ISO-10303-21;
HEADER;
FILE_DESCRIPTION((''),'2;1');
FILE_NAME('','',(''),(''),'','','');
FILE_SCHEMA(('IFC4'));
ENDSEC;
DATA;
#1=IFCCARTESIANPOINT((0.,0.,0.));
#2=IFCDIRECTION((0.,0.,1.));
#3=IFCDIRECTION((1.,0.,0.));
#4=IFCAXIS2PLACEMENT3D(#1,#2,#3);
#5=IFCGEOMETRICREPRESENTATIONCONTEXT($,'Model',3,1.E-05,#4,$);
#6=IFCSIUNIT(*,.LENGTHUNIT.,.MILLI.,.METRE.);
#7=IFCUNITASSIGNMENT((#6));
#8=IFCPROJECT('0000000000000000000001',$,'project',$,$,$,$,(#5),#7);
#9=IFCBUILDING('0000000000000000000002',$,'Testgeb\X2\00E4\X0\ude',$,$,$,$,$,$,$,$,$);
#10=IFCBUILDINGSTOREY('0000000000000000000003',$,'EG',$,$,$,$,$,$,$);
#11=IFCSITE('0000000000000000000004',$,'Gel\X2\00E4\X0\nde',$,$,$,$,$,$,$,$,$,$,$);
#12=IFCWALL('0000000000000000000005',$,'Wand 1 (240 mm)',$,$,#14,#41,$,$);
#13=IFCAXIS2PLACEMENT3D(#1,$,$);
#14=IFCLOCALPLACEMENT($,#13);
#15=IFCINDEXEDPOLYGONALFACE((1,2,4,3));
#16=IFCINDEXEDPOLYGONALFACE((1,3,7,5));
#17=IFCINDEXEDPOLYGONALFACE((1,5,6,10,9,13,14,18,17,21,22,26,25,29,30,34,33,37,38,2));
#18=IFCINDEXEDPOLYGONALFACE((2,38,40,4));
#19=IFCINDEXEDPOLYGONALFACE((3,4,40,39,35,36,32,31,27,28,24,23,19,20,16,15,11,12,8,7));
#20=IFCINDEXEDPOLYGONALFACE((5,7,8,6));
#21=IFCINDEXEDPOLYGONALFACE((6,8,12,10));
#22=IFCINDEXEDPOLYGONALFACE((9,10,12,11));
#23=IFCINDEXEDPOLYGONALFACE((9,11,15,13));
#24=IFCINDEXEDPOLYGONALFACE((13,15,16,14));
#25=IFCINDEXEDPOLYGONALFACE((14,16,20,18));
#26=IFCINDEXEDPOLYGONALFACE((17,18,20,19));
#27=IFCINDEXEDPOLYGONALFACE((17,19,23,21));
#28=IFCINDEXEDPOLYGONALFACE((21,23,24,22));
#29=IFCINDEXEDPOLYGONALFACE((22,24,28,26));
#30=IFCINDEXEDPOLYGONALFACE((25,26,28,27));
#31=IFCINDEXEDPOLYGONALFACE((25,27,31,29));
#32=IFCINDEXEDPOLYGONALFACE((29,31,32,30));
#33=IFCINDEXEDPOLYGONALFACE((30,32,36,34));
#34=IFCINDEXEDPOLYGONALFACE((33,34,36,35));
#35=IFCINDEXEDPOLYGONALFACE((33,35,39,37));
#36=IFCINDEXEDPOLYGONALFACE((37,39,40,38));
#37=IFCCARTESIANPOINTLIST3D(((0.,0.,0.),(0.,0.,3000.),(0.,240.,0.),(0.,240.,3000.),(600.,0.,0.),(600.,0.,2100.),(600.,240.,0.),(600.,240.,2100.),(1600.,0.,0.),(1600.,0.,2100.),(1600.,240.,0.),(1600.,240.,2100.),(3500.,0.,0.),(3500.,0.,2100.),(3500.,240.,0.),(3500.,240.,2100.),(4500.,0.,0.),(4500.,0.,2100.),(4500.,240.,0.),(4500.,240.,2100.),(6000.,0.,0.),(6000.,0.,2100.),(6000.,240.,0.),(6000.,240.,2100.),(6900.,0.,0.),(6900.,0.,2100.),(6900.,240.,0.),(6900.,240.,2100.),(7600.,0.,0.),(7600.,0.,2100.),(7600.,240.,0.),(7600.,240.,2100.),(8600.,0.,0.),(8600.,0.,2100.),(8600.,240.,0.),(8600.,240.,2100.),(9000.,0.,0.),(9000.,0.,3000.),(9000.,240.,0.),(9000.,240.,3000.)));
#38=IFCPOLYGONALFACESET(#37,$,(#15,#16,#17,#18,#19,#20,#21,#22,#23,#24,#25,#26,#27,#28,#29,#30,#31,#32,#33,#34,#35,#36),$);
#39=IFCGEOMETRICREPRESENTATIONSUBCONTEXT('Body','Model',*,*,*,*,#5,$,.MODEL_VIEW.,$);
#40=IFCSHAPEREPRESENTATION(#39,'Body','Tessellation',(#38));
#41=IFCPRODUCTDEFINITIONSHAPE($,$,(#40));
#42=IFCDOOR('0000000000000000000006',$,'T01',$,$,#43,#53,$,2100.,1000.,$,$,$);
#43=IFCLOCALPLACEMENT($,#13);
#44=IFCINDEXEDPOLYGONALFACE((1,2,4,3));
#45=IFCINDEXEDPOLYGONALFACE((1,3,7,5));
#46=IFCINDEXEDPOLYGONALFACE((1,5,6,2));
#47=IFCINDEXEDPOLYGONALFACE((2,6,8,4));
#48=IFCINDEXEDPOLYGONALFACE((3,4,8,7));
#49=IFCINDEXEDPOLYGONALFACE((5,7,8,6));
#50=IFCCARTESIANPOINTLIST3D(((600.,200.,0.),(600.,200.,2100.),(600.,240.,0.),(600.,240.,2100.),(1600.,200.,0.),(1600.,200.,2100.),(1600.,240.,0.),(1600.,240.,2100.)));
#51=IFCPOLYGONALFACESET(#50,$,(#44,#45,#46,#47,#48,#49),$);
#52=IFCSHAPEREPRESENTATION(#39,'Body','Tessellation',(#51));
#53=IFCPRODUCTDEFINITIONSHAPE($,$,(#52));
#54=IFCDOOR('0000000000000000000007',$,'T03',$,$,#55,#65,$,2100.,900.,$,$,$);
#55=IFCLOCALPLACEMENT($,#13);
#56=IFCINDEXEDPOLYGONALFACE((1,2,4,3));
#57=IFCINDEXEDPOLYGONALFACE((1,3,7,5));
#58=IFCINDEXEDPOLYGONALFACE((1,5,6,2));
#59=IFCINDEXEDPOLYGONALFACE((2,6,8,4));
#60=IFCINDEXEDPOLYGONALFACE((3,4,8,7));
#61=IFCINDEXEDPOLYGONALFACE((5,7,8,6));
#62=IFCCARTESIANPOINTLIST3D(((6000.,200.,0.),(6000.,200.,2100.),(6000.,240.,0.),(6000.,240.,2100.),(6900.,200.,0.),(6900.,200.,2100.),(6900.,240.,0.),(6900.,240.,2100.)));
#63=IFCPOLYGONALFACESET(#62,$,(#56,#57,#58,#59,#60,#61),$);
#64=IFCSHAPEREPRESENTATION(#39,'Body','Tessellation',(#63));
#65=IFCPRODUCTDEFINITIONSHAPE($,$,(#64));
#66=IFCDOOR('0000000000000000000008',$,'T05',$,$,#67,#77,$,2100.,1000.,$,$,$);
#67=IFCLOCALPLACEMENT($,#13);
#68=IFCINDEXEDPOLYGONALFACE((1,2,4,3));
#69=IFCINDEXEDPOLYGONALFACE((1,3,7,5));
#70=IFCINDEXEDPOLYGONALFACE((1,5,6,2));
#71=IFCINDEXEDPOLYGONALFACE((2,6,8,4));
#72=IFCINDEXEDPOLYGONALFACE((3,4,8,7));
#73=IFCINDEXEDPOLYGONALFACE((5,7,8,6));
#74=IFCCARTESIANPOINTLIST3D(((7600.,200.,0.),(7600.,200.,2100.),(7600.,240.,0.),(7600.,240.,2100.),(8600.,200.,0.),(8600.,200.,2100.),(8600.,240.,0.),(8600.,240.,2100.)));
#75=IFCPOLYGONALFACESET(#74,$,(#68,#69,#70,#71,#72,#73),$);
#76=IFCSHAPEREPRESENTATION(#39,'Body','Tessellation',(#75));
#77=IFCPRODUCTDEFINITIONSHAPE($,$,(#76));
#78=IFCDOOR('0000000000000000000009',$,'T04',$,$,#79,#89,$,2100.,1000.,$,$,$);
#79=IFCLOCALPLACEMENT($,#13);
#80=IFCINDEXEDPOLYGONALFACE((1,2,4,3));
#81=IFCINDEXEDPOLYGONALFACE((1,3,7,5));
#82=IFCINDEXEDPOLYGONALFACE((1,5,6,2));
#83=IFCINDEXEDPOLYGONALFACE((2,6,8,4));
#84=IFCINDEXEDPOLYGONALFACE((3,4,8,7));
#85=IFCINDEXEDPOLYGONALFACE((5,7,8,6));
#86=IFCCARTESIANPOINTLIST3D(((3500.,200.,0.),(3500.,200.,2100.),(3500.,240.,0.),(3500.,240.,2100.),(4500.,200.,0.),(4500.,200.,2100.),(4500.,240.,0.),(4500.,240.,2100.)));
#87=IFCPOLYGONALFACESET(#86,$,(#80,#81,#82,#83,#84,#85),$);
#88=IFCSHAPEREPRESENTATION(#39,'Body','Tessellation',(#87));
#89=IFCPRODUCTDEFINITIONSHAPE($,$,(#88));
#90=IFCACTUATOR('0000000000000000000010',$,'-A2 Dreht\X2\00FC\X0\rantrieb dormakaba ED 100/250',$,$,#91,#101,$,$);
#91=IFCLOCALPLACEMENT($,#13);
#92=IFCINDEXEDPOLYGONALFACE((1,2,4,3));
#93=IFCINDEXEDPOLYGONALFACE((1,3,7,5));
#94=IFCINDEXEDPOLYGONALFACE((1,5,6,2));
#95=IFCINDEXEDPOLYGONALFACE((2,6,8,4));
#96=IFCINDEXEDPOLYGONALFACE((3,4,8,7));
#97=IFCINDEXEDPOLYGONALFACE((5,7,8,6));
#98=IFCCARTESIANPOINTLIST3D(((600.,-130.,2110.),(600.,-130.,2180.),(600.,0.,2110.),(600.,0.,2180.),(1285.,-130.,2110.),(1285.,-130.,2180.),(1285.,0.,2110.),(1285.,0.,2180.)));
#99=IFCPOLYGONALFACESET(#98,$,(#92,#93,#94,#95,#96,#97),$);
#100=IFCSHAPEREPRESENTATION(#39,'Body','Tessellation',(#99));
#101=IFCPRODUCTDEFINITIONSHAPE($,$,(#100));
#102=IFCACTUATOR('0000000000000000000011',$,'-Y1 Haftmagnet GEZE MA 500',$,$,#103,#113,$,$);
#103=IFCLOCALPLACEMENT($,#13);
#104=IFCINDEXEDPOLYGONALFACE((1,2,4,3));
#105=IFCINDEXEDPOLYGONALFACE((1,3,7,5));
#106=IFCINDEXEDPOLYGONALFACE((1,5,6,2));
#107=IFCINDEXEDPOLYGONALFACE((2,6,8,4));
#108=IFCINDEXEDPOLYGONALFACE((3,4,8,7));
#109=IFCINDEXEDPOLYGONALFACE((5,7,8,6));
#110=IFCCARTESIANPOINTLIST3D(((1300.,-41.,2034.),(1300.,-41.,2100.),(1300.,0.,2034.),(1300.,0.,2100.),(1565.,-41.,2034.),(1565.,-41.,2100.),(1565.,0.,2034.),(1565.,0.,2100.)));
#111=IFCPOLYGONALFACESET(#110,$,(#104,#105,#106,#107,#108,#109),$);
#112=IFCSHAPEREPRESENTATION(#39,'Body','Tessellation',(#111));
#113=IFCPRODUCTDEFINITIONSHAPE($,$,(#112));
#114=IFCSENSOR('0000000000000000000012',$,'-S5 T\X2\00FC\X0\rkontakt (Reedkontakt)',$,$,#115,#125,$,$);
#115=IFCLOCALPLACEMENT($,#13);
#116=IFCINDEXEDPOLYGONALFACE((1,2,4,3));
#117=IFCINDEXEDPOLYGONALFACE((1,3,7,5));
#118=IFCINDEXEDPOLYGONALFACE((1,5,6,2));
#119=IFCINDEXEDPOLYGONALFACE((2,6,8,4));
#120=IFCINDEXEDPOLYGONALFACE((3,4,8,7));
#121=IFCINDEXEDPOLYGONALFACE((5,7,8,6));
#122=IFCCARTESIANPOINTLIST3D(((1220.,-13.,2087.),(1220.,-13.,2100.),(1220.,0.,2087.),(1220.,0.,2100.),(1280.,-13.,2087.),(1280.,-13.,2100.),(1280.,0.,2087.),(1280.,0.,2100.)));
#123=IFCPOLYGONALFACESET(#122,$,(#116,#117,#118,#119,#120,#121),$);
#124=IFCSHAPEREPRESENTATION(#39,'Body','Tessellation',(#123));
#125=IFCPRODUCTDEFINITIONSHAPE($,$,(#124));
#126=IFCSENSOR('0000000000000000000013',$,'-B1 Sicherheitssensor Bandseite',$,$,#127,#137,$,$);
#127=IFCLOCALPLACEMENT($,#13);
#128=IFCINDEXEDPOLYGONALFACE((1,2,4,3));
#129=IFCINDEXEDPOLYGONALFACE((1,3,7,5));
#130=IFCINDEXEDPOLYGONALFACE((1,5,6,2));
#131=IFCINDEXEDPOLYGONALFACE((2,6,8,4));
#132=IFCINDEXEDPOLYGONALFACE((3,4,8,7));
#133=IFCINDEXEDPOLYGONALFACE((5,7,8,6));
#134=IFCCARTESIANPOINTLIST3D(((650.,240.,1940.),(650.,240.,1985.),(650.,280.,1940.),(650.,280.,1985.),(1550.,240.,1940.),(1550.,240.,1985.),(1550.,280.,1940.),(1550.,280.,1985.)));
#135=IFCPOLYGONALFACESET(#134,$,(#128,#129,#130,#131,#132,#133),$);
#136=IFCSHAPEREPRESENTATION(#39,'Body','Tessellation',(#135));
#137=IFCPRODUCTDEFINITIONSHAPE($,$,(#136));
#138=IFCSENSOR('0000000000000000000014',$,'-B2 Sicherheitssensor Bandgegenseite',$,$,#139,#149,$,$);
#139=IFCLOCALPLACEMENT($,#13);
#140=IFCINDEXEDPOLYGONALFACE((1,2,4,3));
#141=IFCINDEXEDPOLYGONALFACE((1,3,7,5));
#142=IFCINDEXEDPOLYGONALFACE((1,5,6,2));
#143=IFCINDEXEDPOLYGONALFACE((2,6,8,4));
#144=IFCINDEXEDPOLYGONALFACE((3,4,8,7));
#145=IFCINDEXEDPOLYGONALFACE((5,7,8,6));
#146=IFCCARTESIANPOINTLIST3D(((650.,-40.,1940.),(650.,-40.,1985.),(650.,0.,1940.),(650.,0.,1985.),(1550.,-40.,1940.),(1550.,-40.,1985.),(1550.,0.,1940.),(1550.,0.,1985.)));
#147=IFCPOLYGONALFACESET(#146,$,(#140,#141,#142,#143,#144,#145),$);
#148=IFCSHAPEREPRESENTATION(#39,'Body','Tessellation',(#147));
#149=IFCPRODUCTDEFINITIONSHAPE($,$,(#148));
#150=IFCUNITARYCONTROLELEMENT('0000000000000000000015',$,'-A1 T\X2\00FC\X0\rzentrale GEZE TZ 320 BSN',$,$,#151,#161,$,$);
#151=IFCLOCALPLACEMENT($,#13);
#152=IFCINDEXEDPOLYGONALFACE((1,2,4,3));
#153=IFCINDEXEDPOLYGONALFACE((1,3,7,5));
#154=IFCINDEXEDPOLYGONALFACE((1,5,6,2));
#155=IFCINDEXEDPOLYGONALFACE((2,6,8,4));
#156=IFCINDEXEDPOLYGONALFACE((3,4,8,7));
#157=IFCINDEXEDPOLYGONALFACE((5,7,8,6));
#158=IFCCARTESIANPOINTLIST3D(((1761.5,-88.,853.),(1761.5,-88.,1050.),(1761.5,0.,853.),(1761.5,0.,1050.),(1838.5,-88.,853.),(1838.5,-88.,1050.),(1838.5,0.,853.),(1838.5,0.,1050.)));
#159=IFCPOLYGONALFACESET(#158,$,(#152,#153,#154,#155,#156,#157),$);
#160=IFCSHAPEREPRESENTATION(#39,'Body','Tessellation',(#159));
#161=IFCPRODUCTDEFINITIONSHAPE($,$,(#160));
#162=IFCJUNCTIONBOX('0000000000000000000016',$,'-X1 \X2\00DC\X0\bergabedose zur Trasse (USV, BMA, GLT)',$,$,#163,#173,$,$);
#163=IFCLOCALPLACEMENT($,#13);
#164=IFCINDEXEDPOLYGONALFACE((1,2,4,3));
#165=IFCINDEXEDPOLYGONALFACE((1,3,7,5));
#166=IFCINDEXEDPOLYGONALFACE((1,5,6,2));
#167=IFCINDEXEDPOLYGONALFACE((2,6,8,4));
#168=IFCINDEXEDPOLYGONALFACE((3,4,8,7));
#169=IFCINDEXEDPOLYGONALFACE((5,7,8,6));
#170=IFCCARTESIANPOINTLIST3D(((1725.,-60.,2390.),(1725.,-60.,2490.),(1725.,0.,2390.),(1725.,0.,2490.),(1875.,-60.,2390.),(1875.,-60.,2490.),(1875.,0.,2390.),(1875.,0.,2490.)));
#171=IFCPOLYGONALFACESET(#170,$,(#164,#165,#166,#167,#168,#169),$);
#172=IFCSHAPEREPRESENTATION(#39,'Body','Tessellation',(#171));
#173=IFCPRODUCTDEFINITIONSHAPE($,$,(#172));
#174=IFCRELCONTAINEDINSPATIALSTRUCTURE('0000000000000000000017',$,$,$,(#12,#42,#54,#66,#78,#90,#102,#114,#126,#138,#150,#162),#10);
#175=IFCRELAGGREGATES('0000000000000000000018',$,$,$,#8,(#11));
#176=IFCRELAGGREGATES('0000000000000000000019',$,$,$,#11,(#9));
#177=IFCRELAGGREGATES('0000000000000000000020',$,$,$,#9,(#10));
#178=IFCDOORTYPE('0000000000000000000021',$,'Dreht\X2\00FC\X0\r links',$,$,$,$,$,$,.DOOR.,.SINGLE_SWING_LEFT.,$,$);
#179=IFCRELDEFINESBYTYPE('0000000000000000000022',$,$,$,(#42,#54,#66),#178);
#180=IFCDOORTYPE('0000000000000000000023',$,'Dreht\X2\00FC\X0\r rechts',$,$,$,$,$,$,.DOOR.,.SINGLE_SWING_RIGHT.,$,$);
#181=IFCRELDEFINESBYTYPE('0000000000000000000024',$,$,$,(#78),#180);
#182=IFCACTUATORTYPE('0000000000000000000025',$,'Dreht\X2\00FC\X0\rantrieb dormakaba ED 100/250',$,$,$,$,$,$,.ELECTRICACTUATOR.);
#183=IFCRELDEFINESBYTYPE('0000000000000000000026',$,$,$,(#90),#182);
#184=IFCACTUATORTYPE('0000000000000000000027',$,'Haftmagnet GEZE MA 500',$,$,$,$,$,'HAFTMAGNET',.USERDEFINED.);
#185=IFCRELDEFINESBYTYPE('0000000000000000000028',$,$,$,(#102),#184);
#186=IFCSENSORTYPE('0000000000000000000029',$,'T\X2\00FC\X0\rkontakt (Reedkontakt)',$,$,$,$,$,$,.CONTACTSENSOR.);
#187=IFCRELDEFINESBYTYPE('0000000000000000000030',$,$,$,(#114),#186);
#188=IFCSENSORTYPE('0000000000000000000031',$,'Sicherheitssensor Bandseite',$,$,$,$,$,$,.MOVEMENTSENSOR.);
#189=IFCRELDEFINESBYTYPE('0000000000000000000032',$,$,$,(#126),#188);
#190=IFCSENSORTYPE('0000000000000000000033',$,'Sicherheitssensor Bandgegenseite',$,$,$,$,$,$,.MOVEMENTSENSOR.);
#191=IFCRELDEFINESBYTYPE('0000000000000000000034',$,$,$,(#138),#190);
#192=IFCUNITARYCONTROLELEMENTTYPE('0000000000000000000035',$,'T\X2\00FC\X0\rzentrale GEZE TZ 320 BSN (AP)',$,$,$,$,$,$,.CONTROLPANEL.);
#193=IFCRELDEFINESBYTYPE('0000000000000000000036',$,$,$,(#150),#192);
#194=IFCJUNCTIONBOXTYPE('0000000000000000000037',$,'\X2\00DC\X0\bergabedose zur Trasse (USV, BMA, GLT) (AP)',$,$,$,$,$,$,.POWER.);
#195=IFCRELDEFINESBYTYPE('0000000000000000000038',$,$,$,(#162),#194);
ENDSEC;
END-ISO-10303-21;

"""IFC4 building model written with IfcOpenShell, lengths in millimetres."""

from ifc_helpers import new_model, si_unit, frame, frame_2d, origin_with_axes, place, context, subcontext, project, spatial, rectangle, extrude, type_object, element, fill, save


model = new_model("IFC4")

# Units and contexts
model_context = context("Model", 3, precision=1e-05, world=origin_with_axes())
body_context = subcontext(model_context, "Body", "Model", "MODEL_VIEW")
ifc_project = project(units=[si_unit("LENGTHUNIT", "METRE", prefix="MILLI")], contexts=[model_context])

# Site, building, storey
site = spatial("IfcSite", under=ifc_project, Name="Gelände")
building = spatial("IfcBuilding", under=site, Name="Testgebäude")
storey = spatial("IfcBuildingStorey", under=building, Name="EG")

# Wall, openings, doors
wall_placement = place(None, origin_with_axes())
wall = element("IfcWall", 1, at=wall_placement, inside=storey, Name="Wand 1 (240 mm)", context=body_context, shape_type="SweptSolid", body=[
    extrude(rectangle(XDim=9000.0, YDim=240.0, at=frame_2d((4500.0, 120.0))), None, (0.0, 0.0, 1.0), 3000.0),
])
opening_1_placement = place(None, frame((600.0, 0.0, 0.0), z_axis=(0.0, 0.0, 1.0), x_axis=(1.0, 0.0, 0.0)))
opening_1 = element("IfcOpeningElement", 2, at=opening_1_placement, cuts=wall, context=body_context, shape_type="SweptSolid", body=[
    extrude(rectangle(XDim=1000.0, YDim=240.0, at=frame_2d((500.0, 120.0))), None, (0.0, 0.0, 1.0), 2100.0),
])
opening_2_placement = place(None, frame((3500.0, 0.0, 0.0), z_axis=(0.0, 0.0, 1.0), x_axis=(1.0, 0.0, 0.0)))
opening_2 = element("IfcOpeningElement", 3, at=opening_2_placement, cuts=wall, context=body_context, shape_type="SweptSolid", body=[
    extrude(rectangle(XDim=1000.0, YDim=240.0, at=frame_2d((500.0, 120.0))), None, (0.0, 0.0, 1.0), 2100.0),
])
opening_3_placement = place(None, frame((6000.0, 0.0, 0.0), z_axis=(0.0, 0.0, 1.0), x_axis=(1.0, 0.0, 0.0)))
opening_3 = element("IfcOpeningElement", 4, at=opening_3_placement, cuts=wall, context=body_context, shape_type="SweptSolid", body=[
    extrude(rectangle(XDim=900.0, YDim=240.0, at=frame_2d((450.0, 120.0))), None, (0.0, 0.0, 1.0), 2100.0),
])
opening_4_placement = place(None, frame((7600.0, 0.0, 0.0), z_axis=(0.0, 0.0, 1.0), x_axis=(1.0, 0.0, 0.0)))
opening_4 = element("IfcOpeningElement", 5, at=opening_4_placement, cuts=wall, context=body_context, shape_type="SweptSolid", body=[
    extrude(rectangle(XDim=1000.0, YDim=240.0, at=frame_2d((500.0, 120.0))), None, (0.0, 0.0, 1.0), 2100.0),
])
door_type_1 = type_object("IfcDoorType", Name="Drehtür links", OperationType="SINGLE_SWING_LEFT", PredefinedType="DOOR")
door_1_placement = place(opening_1_placement, origin_with_axes())
door_1 = element("IfcDoor", 6, at=door_1_placement, inside=storey, type_object=door_type_1, Name="T01", OverallHeight=2100.0, OverallWidth=1000.0, context=body_context, shape_type="SweptSolid", body=[
    extrude(rectangle(XDim=1000.0, YDim=40.0, at=frame_2d((500.0, 20.0))), frame((0.0, 200.0, 0.0)), (0.0, 0.0, 1.0), 2100.0),
])
fill(opening_1, door_1)
door_2_placement = place(opening_3_placement, origin_with_axes())
door_2 = element("IfcDoor", 7, at=door_2_placement, inside=storey, type_object=door_type_1, Name="T03", OverallHeight=2100.0, OverallWidth=900.0, context=body_context, shape_type="SweptSolid", body=[
    extrude(rectangle(XDim=900.0, YDim=40.0, at=frame_2d((450.0, 20.0))), frame((0.0, 200.0, 0.0)), (0.0, 0.0, 1.0), 2100.0),
])
fill(opening_3, door_2)
door_3_placement = place(opening_4_placement, origin_with_axes())
door_3 = element("IfcDoor", 8, at=door_3_placement, inside=storey, type_object=door_type_1, Name="T05", OverallHeight=2100.0, OverallWidth=1000.0, context=body_context, shape_type="SweptSolid", body=[
    extrude(rectangle(XDim=1000.0, YDim=40.0, at=frame_2d((500.0, 20.0))), frame((0.0, 200.0, 0.0)), (0.0, 0.0, 1.0), 2100.0),
])
fill(opening_4, door_3)
door_type_2 = type_object("IfcDoorType", Name="Drehtür rechts", OperationType="SINGLE_SWING_RIGHT", PredefinedType="DOOR")
door_4_placement = place(opening_2_placement, origin_with_axes())
door_4 = element("IfcDoor", 9, at=door_4_placement, inside=storey, type_object=door_type_2, Name="T04", OverallHeight=2100.0, OverallWidth=1000.0, context=body_context, shape_type="SweptSolid", body=[
    extrude(rectangle(XDim=1000.0, YDim=40.0, at=frame_2d((500.0, 20.0))), frame((0.0, 200.0, 0.0)), (0.0, 0.0, 1.0), 2100.0),
])
fill(opening_2, door_4)

# Actuators
actuator_type_1 = type_object("IfcActuatorType", Name="Drehtürantrieb dormakaba ED 100/250", PredefinedType="ELECTRICACTUATOR")
actuator_1_placement = place(None, frame((600.0, -130.0, 2110.0), z_axis=(0.0, 0.0, 1.0), x_axis=(1.0, 0.0, 0.0)))
element("IfcActuator", 10, at=actuator_1_placement, inside=storey, type_object=actuator_type_1, Name="-A2 Drehtürantrieb dormakaba ED 100/250", context=body_context, shape_type="SweptSolid", body=[
    extrude(rectangle(XDim=685.0, YDim=130.0, at=frame_2d((342.5, 65.0))), None, (0.0, 0.0, 1.0), 70.0),
])
actuator_type_2 = type_object("IfcActuatorType", Name="Haftmagnet GEZE MA 500", ElementType="HAFTMAGNET", PredefinedType="USERDEFINED")
actuator_2_placement = place(None, frame((1300.0, -41.0, 2034.0), z_axis=(0.0, 0.0, 1.0), x_axis=(1.0, 0.0, 0.0)))
element("IfcActuator", 11, at=actuator_2_placement, inside=storey, type_object=actuator_type_2, Name="-Y1 Haftmagnet GEZE MA 500", context=body_context, shape_type="SweptSolid", body=[
    extrude(rectangle(XDim=265.0, YDim=41.0, at=frame_2d((132.5, 20.5))), None, (0.0, 0.0, 1.0), 66.0),
])

# Sensors
sensor_type_1 = type_object("IfcSensorType", Name="Türkontakt (Reedkontakt)", PredefinedType="CONTACTSENSOR")
sensor_1_placement = place(None, frame((1220.0, -13.0, 2087.0), z_axis=(0.0, 0.0, 1.0), x_axis=(1.0, 0.0, 0.0)))
element("IfcSensor", 12, at=sensor_1_placement, inside=storey, type_object=sensor_type_1, Name="-S5 Türkontakt (Reedkontakt)", context=body_context, shape_type="SweptSolid", body=[
    extrude(rectangle(XDim=60.0, YDim=13.0, at=frame_2d((30.0, 6.5))), None, (0.0, 0.0, 1.0), 13.0),
])
sensor_type_2 = type_object("IfcSensorType", Name="Sicherheitssensor Bandseite", PredefinedType="MOVEMENTSENSOR")
sensor_2_placement = place(None, frame((650.0, 240.0, 1940.0), z_axis=(0.0, 0.0, 1.0), x_axis=(1.0, 0.0, 0.0)))
element("IfcSensor", 13, at=sensor_2_placement, inside=storey, type_object=sensor_type_2, Name="-B1 Sicherheitssensor Bandseite", context=body_context, shape_type="SweptSolid", body=[
    extrude(rectangle(XDim=900.0, YDim=40.0, at=frame_2d((450.0, 20.0))), None, (0.0, 0.0, 1.0), 45.0),
])
sensor_type_3 = type_object("IfcSensorType", Name="Sicherheitssensor Bandgegenseite", PredefinedType="MOVEMENTSENSOR")
sensor_3_placement = place(None, frame((650.0, -40.0, 1940.0), z_axis=(0.0, 0.0, 1.0), x_axis=(1.0, 0.0, 0.0)))
element("IfcSensor", 14, at=sensor_3_placement, inside=storey, type_object=sensor_type_3, Name="-B2 Sicherheitssensor Bandgegenseite", context=body_context, shape_type="SweptSolid", body=[
    extrude(rectangle(XDim=900.0, YDim=40.0, at=frame_2d((450.0, 20.0))), None, (0.0, 0.0, 1.0), 45.0),
])

# Unitary control element
unitary_control_element_type = type_object("IfcUnitaryControlElementType", Name="Türzentrale GEZE TZ 320 BSN (AP)", PredefinedType="CONTROLPANEL")
unitary_control_element_placement = place(None, frame((1761.5, -88.0, 853.0), z_axis=(0.0, 0.0, 1.0), x_axis=(1.0, 0.0, 0.0)))
element("IfcUnitaryControlElement", 15, at=unitary_control_element_placement, inside=storey, type_object=unitary_control_element_type, Name="-A1 Türzentrale GEZE TZ 320 BSN", context=body_context, shape_type="SweptSolid", body=[
    extrude(rectangle(XDim=77.0, YDim=88.0, at=frame_2d((38.5, 44.0))), None, (0.0, 0.0, 1.0), 197.0),
])

# Junction box
junction_box_type = type_object("IfcJunctionBoxType", Name="Übergabedose zur Trasse (USV, BMA, GLT) (AP)", PredefinedType="POWER")
junction_box_placement = place(None, frame((1725.0, -60.0, 2390.0), z_axis=(0.0, 0.0, 1.0), x_axis=(1.0, 0.0, 0.0)))
element("IfcJunctionBox", 16, at=junction_box_placement, inside=storey, type_object=junction_box_type, Name="-X1 Übergabedose zur Trasse (USV, BMA, GLT)", context=body_context, shape_type="SweptSolid", body=[
    extrude(rectangle(XDim=150.0, YDim=60.0, at=frame_2d((75.0, 30.0))), None, (0.0, 0.0, 1.0), 100.0),
])

save(model, "model.ifc")
